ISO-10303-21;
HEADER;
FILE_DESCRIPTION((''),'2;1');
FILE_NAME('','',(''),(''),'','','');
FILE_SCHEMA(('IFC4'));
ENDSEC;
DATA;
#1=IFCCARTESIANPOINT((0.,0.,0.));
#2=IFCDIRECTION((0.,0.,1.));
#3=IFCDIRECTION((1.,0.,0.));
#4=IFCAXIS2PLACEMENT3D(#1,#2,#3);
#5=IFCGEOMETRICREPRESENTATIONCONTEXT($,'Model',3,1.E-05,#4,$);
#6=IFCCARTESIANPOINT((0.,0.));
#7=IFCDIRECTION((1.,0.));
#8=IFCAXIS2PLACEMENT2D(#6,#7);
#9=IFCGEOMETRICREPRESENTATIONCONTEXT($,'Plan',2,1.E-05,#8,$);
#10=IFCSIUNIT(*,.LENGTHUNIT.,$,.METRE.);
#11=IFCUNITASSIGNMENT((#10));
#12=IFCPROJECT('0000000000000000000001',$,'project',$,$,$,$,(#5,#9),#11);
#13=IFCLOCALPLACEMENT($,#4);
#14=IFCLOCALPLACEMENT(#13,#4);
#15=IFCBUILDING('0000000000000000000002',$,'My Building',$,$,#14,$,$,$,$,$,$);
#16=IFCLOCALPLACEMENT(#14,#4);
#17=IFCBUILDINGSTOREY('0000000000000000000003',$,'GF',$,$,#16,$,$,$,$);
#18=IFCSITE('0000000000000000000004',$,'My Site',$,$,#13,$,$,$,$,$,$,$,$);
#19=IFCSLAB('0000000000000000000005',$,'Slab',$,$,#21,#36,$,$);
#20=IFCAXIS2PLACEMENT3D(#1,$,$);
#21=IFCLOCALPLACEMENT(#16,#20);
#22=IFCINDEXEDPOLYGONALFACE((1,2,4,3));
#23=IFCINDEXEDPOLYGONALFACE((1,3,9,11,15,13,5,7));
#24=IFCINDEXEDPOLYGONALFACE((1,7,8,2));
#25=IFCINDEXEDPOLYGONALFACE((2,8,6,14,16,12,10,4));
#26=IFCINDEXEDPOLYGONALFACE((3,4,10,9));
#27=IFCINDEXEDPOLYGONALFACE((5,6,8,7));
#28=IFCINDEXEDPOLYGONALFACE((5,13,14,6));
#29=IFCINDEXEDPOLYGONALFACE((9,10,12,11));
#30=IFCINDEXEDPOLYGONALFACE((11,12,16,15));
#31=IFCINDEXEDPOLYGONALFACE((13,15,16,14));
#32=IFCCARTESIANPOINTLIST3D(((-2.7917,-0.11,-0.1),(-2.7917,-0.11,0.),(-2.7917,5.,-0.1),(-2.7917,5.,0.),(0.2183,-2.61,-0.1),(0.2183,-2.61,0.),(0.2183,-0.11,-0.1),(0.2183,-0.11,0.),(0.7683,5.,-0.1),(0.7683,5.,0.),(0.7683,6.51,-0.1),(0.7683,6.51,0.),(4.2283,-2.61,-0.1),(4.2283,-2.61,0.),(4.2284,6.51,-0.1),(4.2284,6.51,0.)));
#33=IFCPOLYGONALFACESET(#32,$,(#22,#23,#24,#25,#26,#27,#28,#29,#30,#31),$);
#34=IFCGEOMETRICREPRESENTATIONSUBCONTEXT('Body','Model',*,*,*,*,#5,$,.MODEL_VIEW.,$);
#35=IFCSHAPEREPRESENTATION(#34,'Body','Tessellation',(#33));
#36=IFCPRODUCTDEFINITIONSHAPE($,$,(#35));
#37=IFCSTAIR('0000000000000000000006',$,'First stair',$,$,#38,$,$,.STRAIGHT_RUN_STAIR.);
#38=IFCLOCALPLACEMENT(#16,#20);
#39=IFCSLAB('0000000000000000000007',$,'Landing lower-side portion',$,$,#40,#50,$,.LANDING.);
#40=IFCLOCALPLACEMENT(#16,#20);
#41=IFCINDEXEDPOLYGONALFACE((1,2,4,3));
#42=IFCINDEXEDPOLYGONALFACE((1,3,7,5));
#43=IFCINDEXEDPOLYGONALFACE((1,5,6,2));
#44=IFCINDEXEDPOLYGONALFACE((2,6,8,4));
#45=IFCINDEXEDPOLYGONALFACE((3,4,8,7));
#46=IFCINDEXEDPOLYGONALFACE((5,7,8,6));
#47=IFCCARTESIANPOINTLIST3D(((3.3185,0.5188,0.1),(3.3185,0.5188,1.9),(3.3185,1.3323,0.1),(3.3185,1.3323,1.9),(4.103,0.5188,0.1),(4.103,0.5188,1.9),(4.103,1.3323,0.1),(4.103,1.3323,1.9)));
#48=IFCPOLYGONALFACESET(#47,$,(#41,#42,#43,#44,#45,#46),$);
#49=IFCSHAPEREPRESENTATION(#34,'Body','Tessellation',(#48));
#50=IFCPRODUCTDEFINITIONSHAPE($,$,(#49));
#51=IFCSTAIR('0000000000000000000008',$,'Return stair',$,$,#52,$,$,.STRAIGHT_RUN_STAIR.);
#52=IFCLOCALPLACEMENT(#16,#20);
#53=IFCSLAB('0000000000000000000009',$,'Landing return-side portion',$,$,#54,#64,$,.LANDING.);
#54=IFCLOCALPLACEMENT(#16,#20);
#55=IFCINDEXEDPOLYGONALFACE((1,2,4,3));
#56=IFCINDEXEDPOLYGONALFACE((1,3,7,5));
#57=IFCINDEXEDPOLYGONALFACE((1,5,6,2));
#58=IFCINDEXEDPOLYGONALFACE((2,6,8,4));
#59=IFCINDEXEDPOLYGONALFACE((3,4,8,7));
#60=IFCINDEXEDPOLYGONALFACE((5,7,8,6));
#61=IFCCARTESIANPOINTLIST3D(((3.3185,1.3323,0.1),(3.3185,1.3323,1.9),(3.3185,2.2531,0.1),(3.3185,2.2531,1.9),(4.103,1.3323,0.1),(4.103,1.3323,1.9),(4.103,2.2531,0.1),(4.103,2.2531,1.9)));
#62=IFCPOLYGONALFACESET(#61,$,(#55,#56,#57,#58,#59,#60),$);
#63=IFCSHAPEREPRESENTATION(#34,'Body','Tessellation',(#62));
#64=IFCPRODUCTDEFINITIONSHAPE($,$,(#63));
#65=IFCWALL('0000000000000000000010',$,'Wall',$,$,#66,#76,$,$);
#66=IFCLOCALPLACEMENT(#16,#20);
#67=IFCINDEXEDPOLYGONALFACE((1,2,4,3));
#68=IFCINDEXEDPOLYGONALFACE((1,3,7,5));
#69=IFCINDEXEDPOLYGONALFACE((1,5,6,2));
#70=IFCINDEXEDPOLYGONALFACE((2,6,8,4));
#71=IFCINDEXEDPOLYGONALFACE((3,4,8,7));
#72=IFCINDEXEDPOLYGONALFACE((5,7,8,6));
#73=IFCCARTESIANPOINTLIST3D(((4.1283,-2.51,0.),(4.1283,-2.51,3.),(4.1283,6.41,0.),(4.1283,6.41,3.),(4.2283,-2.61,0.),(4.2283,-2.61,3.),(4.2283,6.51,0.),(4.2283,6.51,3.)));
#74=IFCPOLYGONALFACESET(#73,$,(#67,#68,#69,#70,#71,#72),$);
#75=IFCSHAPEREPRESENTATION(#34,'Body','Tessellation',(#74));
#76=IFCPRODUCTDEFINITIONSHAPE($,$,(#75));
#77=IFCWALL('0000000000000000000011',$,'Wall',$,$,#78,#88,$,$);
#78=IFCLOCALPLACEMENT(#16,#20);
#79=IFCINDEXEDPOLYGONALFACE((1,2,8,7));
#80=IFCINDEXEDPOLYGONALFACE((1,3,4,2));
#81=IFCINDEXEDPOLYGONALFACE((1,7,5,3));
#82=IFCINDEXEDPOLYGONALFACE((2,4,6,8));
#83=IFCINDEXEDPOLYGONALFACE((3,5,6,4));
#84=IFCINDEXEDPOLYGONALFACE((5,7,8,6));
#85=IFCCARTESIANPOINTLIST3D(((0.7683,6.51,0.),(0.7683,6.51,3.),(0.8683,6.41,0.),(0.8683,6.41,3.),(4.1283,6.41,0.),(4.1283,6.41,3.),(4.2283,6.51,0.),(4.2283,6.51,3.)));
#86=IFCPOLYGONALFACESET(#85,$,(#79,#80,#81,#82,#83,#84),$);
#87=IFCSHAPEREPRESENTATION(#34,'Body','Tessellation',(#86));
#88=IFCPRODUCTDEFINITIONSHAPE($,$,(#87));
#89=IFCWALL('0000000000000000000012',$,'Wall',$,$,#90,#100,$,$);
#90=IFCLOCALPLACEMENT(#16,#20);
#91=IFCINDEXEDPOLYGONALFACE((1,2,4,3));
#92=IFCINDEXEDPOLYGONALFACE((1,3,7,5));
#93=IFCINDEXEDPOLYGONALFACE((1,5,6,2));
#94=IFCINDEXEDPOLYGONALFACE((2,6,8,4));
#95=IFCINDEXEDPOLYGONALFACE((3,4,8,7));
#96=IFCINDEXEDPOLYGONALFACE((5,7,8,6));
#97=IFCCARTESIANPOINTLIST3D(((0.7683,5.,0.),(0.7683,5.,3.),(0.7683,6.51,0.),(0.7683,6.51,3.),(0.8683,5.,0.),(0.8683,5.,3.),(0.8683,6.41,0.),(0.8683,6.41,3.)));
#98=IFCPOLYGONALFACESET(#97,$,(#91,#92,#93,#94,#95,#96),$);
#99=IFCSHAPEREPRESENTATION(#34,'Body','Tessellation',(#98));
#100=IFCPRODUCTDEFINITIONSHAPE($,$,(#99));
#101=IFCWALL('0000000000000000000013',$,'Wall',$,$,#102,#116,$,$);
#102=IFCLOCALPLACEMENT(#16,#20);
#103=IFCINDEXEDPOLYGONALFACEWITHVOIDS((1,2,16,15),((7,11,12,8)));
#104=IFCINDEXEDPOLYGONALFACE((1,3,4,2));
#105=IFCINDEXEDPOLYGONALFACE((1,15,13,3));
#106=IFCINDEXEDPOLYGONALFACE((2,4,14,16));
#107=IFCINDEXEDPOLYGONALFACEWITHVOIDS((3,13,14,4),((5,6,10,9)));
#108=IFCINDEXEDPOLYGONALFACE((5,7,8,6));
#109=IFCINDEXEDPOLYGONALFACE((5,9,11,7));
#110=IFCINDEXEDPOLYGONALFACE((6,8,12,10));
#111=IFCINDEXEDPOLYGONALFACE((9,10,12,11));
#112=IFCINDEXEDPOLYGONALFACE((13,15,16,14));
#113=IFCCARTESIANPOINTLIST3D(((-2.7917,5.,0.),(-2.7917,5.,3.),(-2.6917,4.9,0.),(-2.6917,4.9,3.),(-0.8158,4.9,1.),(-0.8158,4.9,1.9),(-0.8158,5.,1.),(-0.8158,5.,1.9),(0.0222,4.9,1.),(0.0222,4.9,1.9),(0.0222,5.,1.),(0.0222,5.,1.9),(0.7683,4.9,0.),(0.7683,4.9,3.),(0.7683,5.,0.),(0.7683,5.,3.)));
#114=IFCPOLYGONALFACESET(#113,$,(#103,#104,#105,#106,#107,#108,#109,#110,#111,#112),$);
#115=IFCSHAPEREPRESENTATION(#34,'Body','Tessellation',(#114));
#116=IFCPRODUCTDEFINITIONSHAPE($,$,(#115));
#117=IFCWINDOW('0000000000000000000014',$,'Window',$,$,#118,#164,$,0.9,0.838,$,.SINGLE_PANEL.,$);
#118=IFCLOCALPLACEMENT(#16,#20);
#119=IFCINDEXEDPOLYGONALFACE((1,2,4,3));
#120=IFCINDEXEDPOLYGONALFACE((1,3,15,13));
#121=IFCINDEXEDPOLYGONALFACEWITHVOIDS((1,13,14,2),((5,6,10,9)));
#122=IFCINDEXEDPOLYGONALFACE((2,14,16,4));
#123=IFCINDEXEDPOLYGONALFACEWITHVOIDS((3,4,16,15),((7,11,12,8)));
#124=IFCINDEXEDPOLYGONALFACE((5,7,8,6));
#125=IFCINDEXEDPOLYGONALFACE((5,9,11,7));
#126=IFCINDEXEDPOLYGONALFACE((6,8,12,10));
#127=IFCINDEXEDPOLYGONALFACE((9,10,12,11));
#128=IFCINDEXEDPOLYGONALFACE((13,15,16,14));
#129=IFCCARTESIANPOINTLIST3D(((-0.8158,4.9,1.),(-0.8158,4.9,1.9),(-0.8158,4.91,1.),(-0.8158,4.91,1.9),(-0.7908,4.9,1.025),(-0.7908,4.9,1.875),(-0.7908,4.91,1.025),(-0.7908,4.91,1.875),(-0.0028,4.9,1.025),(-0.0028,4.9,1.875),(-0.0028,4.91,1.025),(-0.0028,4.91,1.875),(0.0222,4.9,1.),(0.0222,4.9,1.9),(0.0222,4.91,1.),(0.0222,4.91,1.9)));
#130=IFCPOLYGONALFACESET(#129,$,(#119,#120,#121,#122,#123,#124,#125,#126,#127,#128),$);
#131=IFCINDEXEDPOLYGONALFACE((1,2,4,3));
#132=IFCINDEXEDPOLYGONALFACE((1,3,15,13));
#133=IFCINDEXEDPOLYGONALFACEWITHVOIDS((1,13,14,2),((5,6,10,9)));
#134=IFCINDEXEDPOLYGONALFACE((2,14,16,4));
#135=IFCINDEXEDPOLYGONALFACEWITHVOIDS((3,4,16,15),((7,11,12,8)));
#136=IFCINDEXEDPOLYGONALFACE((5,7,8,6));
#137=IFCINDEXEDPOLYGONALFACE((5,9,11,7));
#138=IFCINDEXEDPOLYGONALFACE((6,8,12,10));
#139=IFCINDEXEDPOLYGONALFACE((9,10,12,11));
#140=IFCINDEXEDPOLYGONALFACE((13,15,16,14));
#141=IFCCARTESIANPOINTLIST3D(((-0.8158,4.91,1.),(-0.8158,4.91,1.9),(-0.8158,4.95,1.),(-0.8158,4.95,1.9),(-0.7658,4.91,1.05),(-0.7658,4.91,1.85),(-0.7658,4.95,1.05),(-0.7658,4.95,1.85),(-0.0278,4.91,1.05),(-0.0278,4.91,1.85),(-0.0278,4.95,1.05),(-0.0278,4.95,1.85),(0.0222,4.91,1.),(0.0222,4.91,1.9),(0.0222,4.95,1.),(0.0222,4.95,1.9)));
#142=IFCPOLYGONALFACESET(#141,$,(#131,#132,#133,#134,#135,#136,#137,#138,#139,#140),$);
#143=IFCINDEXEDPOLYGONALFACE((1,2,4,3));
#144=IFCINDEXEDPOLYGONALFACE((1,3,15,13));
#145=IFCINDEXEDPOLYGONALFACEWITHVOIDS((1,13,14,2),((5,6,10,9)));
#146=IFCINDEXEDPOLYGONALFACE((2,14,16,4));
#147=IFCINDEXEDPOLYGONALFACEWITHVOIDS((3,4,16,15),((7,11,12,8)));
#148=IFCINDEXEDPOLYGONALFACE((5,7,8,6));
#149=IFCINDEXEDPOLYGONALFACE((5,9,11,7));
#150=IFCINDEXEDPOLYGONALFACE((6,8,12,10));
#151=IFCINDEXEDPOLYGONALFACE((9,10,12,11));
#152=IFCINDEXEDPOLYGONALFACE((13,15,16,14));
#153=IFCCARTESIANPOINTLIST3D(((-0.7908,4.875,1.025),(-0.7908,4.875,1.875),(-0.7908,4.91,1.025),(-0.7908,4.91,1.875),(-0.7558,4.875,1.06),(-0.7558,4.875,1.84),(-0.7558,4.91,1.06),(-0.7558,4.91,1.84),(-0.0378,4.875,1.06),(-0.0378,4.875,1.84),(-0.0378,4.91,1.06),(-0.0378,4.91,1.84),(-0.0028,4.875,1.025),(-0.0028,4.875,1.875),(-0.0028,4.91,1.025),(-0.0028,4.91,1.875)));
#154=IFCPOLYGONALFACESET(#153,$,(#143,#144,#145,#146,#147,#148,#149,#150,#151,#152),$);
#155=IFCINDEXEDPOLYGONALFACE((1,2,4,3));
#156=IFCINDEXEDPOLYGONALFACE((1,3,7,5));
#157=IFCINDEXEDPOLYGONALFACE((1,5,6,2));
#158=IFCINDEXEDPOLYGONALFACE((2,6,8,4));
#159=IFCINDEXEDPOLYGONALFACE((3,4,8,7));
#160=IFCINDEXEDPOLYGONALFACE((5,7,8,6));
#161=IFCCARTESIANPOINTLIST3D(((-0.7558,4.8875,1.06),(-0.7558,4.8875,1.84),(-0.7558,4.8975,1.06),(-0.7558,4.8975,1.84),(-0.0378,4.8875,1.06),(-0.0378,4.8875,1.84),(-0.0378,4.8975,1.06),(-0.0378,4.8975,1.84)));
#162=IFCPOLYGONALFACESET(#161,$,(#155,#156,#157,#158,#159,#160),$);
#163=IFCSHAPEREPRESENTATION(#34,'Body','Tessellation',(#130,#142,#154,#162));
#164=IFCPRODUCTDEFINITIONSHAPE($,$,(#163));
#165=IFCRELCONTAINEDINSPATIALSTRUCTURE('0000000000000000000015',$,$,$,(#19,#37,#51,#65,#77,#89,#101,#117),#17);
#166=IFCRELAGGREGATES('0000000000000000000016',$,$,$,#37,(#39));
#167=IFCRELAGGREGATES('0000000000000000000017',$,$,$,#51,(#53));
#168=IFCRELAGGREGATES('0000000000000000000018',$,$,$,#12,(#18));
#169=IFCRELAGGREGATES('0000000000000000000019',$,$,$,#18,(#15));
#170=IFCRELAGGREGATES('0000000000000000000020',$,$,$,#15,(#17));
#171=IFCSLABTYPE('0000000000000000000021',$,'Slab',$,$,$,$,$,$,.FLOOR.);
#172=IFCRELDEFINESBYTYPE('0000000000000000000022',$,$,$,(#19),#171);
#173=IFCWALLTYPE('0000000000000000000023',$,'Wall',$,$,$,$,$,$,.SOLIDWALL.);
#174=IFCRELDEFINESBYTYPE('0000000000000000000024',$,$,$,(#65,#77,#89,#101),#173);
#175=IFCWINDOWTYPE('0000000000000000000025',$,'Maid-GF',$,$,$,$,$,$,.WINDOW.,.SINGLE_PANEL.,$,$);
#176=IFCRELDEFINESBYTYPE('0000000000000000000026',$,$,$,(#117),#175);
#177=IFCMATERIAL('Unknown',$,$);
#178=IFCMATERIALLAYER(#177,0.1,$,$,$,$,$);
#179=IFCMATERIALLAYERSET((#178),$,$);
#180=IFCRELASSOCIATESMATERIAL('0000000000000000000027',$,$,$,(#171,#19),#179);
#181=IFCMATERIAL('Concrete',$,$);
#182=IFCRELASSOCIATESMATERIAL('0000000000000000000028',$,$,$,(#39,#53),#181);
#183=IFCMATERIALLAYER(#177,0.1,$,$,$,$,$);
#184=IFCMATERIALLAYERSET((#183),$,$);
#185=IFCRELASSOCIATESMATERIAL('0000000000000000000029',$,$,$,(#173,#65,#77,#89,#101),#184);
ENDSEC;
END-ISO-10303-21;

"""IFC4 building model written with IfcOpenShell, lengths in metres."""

from ifc_helpers import new_model, entity, si_unit, frame, origin_with_axes, origin_2d_with_axis, place, context, subcontext, project, spatial, line, indexed_curve, outline, extrude, shape, source, transform, mapped, material, layer, layer_set, layer_usage, type_object, type_shapes, element, fill, aggregate, save


model = new_model("IFC4")

# Units and contexts
model_context_1 = context("Model", 3, precision=1e-05, world=origin_with_axes())
plan_context = context("Plan", 2, precision=1e-05, world=origin_2d_with_axis())
body_context_1 = subcontext(model_context_1, "Body", "Model", "MODEL_VIEW")
body_context_2 = subcontext(plan_context, "Body", "Plan", "PLAN_VIEW")
ifc_project = project(units=[si_unit("LENGTHUNIT", "METRE")], contexts=[model_context_1, plan_context])

# Site, building, storey
site_placement = place(None, origin_with_axes())
site = spatial("IfcSite", under=ifc_project, at=site_placement, Name="My Site")
building_placement = place(site_placement, origin_with_axes())
building = spatial("IfcBuilding", under=site, at=building_placement, Name="My Building")
storey_placement = place(building_placement, origin_with_axes())
storey = spatial("IfcBuildingStorey", under=building, at=storey_placement, Name="GF")

# Slab
ifc_material_1 = material(Name="Unknown")
ifc_layer_1 = layer(ifc_material_1, 0.1)
ifc_layer_set_1 = layer_set([ifc_layer_1])
ifc_layer_usage_1 = layer_usage(ifc_layer_set_1, "AXIS3", "POSITIVE", -0.1)
slab_type = type_object("IfcSlabType", Name="Slab", PredefinedType="FLOOR", material=ifc_layer_set_1)
slab_1_placement = place(storey_placement, frame((0.2183, -2.61, 0.0), z_axis=(0.0, 0.0, 1.0), x_axis=(1.0, 0.0, 0.0)))
element("IfcSlab", 1, at=slab_1_placement, inside=storey, type_object=slab_type, material=ifc_layer_usage_1, Name="Slab", context=body_context_1, shape_type="SweptSolid", body=[
    extrude(outline(indexed_curve([(4.01, 0.0), (4.01, 9.12), (0.55, 9.12), (0.55, 7.61), (-3.01, 7.61), (-3.01, 2.5), (0.0, 2.5), (0.0, 0.0), (4.01, 0.0)])), frame((0.0, 0.0, -0.1), z_axis=(0.0, 0.0, 1.0), x_axis=(1.0, 0.0, 0.0)), (0.0, 0.0, 1.0), 0.1),
])

# Stairs, slabs
stair_1_placement = place(storey_placement, origin_with_axes())
stair_1 = element("IfcStair", 2, at=stair_1_placement, inside=storey, Name="First stair", PredefinedType="STRAIGHT_RUN_STAIR")
ifc_material_2 = material(Name="Concrete")
slab_2_placement = place(stair_1_placement, frame((0.0, 0.0, 0.1), z_axis=(0.0, 0.0, 1.0), x_axis=(1.0, 0.0, 0.0)))
slab_2 = element("IfcSlab", 3, at=slab_2_placement, material=ifc_material_2, Name="Landing lower-side portion", PredefinedType="LANDING", context=body_context_1, shape_type="SweptSolid", body=[
    extrude(outline(indexed_curve([(3.3185, 0.5188), (4.103, 0.5188), (4.103, 1.3323), (3.3185, 1.3323), (3.3185, 0.5188)])), origin_with_axes(), (0.0, 0.0, 1.0), 1.8),
])
aggregate(stair_1, [slab_2])
stair_2_placement = place(storey_placement, origin_with_axes())
stair_2 = element("IfcStair", 4, at=stair_2_placement, inside=storey, Name="Return stair", PredefinedType="STRAIGHT_RUN_STAIR")
slab_3_placement = place(stair_2_placement, frame((0.0, 0.0, 0.1), z_axis=(0.0, 0.0, 1.0), x_axis=(1.0, 0.0, 0.0)))
slab_3 = element("IfcSlab", 5, at=slab_3_placement, material=ifc_material_2, Name="Landing return-side portion", PredefinedType="LANDING", context=body_context_1, shape_type="SweptSolid", body=[
    extrude(outline(indexed_curve([(3.3185, 1.3323), (4.103, 1.3323), (4.103, 2.2531), (3.3185, 2.2531), (3.3185, 1.3323)])), origin_with_axes(), (0.0, 0.0, 1.0), 1.8),
])
aggregate(stair_2, [slab_3])

# Shared definitions
ifc_layer_2 = layer(ifc_material_1, 0.1)
ifc_layer_set_2 = layer_set([ifc_layer_2])
wall_type = type_object("IfcWallType", Name="Wall", PredefinedType="SOLIDWALL", material=ifc_layer_set_2)

# Walls
ifc_layer_usage_2 = layer_usage(ifc_layer_set_2, "AXIS2", "POSITIVE", 0.0)
wall_1_placement = place(storey_placement, frame((4.2283, -2.61, 0.0), z_axis=(0.0, 0.0, 1.0), x_axis=(0.0, 1.0, 0.0)))
element("IfcWall", 6, at=wall_1_placement, inside=storey, type_object=wall_type, material=ifc_layer_usage_2, Name="Wall", context=body_context_1, shape_type="SweptSolid", body=[
    extrude(outline(indexed_curve([(0.0, 0.0), (0.1, 0.1), (9.02, 0.1), (9.12, 0.0)], segments=[line(1, 2, 3, 4, 1)])), origin_with_axes(), (0.0, 0.0, 1.0), 3.0),
])
ifc_layer_usage_3 = layer_usage(ifc_layer_set_2, "AXIS2", "POSITIVE", 0.0)
wall_2_placement = place(storey_placement, frame((4.2283, 6.51, 0.0), z_axis=(0.0, 0.0, 1.0), x_axis=(-1.0, 0.0, 0.0)))
element("IfcWall", 7, at=wall_2_placement, inside=storey, type_object=wall_type, material=ifc_layer_usage_3, Name="Wall", context=body_context_1, shape_type="SweptSolid", body=[
    extrude(outline(indexed_curve([(0.0, 0.0), (0.1, 0.1), (3.36, 0.1), (3.46, 0.0)], segments=[line(1, 2, 3, 4, 1)])), origin_with_axes(), (0.0, 0.0, 1.0), 3.0),
])
ifc_layer_usage_4 = layer_usage(ifc_layer_set_2, "AXIS2", "POSITIVE", 0.0)
wall_3_placement = place(storey_placement, frame((0.7683, 6.51, 0.0), z_axis=(0.0, 0.0, 1.0), x_axis=(0.0, -1.0, 0.0)))
element("IfcWall", 8, at=wall_3_placement, inside=storey, type_object=wall_type, material=ifc_layer_usage_4, Name="Wall", context=body_context_1, shape_type="SweptSolid", body=[
    extrude(outline(indexed_curve([(0.0, 0.0), (0.1, 0.1), (1.51, 0.1), (1.51, 0.0)], segments=[line(1, 2, 3, 4, 1)])), origin_with_axes(), (0.0, 0.0, 1.0), 3.0),
])

# Wall, opening, window
ifc_layer_usage_5 = layer_usage(ifc_layer_set_2, "AXIS2", "POSITIVE", 0.0)
wall_4_placement = place(storey_placement, frame((0.7683, 5.0, 0.0), z_axis=(0.0, 0.0, 1.0), x_axis=(-1.0, 0.0, 0.0)))
wall_4 = element("IfcWall", 9, at=wall_4_placement, inside=storey, type_object=wall_type, material=ifc_layer_usage_5, Name="Wall", context=body_context_1, shape_type="SweptSolid", body=[
    extrude(outline(indexed_curve([(0.0, 0.0), (0.0, 0.1), (3.46, 0.1), (3.56, 0.0)], segments=[line(1, 2, 3, 4, 1)])), origin_with_axes(), (0.0, 0.0, 1.0), 3.0),
])
shared_shape_1 = source(origin_with_axes(), body_context_1, "Body", "SweptSolid", [
    extrude(outline(indexed_curve([(0.0, 0.0), (0.838, 0.0), (0.838, 0.9), (0.0, 0.9)], segments=[line(1, 2, 3, 4, 1)])), frame((0.0, -0.6, 0.0), z_axis=(0.0, -1.0, 0.0), x_axis=(1.0, 0.0, 0.0)), (0.0, 0.0, -1.0), 1.2),
])
opening_1_placement = place(wall_4_placement, frame((0.7462, 0.0, 1.0), z_axis=(0.0, 0.0, 1.0), x_axis=(1.0, 0.0, 0.0)))
opening_1 = element("IfcOpeningElement", 10, at=opening_1_placement, cuts=wall_4, PredefinedType="OPENING", context=body_context_1, shape_type="MappedRepresentation", body=[
    mapped(shared_shape_1, transform((0.0, 0.0, 0.0), x_axis=(1.0, 0.0, 0.0), y_axis=(0.0, 1.0, 0.0), z_axis=(0.0, 0.0, 1.0), scale=1.0)),
])
window_type_1 = type_object("IfcWindowType", Name="Maid-GF", PartitioningType="SINGLE_PANEL", PredefinedType="WINDOW")
shared_shape_2 = source(origin_with_axes(), body_context_1, "Body", "SweptSolid", [
    extrude(outline(indexed_curve([(0.0, 0.0), (0.838, 0.0), (0.838, 0.9), (0.0, 0.9)], segments=[line(1, 2, 3, 4, 1)]), holes=[indexed_curve([(0.025, 0.025), (0.813, 0.025), (0.813, 0.875), (0.025, 0.875)], segments=[line(1, 2, 3, 4, 1)])]), frame((0.0, 0.09, 0.0), z_axis=(0.0, -1.0, 0.0), x_axis=(1.0, 0.0, 0.0)), (0.0, 0.0, -1.0), 0.01),
    extrude(outline(indexed_curve([(0.0, 0.0), (0.838, 0.0), (0.838, 0.9), (0.0, 0.9)], segments=[line(1, 2, 3, 4, 1)]), holes=[indexed_curve([(0.05, 0.05), (0.788, 0.05), (0.788, 0.85), (0.05, 0.85)], segments=[line(1, 2, 3, 4, 1)])]), frame((0.0, 0.05, 0.0), z_axis=(0.0, -1.0, 0.0), x_axis=(1.0, 0.0, 0.0)), (0.0, 0.0, -1.0), 0.04),
    extrude(outline(indexed_curve([(0.0, 0.0), (0.788, 0.0), (0.788, 0.85), (0.0, 0.85)], segments=[line(1, 2, 3, 4, 1)]), holes=[indexed_curve([(0.035, 0.035), (0.753, 0.035), (0.753, 0.815), (0.035, 0.815)], segments=[line(1, 2, 3, 4, 1)])]), frame((0.025, 0.09, 0.025), z_axis=(0.0, -1.0, 0.0), x_axis=(1.0, 0.0, 0.0)), (0.0, 0.0, -1.0), 0.035),
    extrude(outline(indexed_curve([(0.035, 0.035), (0.753, 0.035), (0.753, 0.815), (0.035, 0.815)], segments=[line(1, 2, 3, 4, 1)])), frame((0.025, 0.1025, 0.025), z_axis=(0.0, -1.0, 0.0), x_axis=(1.0, 0.0, 0.0)), (0.0, 0.0, -1.0), 0.01),
])
shared_shape_3 = source(origin_with_axes(), body_context_2, "Body", "Curve2D", [
    entity("IfcIndexedPolyCurve", entity("IfcCartesianPointList2D", [[0.05, 0.05], [0.788, 0.05]])),
    entity("IfcIndexedPolyCurve", entity("IfcCartesianPointList2D", [[0.0, 0.1], [0.025, 0.1], [0.025, 0.09], [0.05, 0.09], [0.05, 0.05], [0.0, 0.05]]), [entity("IfcLineIndex", [1, 2, 3, 4, 5, 6, 1])]),
    entity("IfcIndexedPolyCurve", entity("IfcCartesianPointList2D", [[0.838, 0.1], [0.813, 0.1], [0.813, 0.09], [0.788, 0.09], [0.788, 0.05], [0.838, 0.05]]), [entity("IfcLineIndex", [1, 2, 3, 4, 5, 6, 1])]),
    entity("IfcIndexedPolyCurve", entity("IfcCartesianPointList2D", [[0.025, 0.09], [0.06, 0.09], [0.06, 0.125], [0.025, 0.125]]), [entity("IfcLineIndex", [1, 2, 3, 4, 1])]),
    entity("IfcIndexedPolyCurve", entity("IfcCartesianPointList2D", [[0.813, 0.09], [0.778, 0.09], [0.778, 0.125], [0.813, 0.125]]), [entity("IfcLineIndex", [1, 2, 3, 4, 1])]),
    entity("IfcIndexedPolyCurve", entity("IfcCartesianPointList2D", [[0.06, 0.09], [0.778, 0.09]])),
    entity("IfcIndexedPolyCurve", entity("IfcCartesianPointList2D", [[0.06, 0.125], [0.778, 0.125]])),
    entity("IfcIndexedPolyCurve", entity("IfcCartesianPointList2D", [[0.06, 0.1075], [0.778, 0.1075]])),
])
type_shapes(window_type_1, [shared_shape_2, shared_shape_3])
window_1_placement = place(opening_1_placement, origin_with_axes())
window_1 = element("IfcWindow", 11, at=window_1_placement, inside=storey, type_object=window_type_1, Name="Window", OverallHeight=0.9, OverallWidth=0.838, PartitioningType="SINGLE_PANEL", shapes=[
    shape(body_context_1, "Body", "MappedRepresentation", [mapped(shared_shape_2, transform((0.0, 0.0, 0.0), x_axis=(1.0, 0.0, 0.0), y_axis=(0.0, 1.0, 0.0), z_axis=(0.0, 0.0, 1.0), scale=1.0))]),
    shape(body_context_2, "Body", "MappedRepresentation", [mapped(shared_shape_3, transform((0.0, 0.0, 0.0), x_axis=(1.0, 0.0, 0.0), y_axis=(0.0, 1.0, 0.0), z_axis=(0.0, 0.0, 1.0), scale=1.0))]),
])
fill(opening_1, window_1)

save(model, "model.ifc")
